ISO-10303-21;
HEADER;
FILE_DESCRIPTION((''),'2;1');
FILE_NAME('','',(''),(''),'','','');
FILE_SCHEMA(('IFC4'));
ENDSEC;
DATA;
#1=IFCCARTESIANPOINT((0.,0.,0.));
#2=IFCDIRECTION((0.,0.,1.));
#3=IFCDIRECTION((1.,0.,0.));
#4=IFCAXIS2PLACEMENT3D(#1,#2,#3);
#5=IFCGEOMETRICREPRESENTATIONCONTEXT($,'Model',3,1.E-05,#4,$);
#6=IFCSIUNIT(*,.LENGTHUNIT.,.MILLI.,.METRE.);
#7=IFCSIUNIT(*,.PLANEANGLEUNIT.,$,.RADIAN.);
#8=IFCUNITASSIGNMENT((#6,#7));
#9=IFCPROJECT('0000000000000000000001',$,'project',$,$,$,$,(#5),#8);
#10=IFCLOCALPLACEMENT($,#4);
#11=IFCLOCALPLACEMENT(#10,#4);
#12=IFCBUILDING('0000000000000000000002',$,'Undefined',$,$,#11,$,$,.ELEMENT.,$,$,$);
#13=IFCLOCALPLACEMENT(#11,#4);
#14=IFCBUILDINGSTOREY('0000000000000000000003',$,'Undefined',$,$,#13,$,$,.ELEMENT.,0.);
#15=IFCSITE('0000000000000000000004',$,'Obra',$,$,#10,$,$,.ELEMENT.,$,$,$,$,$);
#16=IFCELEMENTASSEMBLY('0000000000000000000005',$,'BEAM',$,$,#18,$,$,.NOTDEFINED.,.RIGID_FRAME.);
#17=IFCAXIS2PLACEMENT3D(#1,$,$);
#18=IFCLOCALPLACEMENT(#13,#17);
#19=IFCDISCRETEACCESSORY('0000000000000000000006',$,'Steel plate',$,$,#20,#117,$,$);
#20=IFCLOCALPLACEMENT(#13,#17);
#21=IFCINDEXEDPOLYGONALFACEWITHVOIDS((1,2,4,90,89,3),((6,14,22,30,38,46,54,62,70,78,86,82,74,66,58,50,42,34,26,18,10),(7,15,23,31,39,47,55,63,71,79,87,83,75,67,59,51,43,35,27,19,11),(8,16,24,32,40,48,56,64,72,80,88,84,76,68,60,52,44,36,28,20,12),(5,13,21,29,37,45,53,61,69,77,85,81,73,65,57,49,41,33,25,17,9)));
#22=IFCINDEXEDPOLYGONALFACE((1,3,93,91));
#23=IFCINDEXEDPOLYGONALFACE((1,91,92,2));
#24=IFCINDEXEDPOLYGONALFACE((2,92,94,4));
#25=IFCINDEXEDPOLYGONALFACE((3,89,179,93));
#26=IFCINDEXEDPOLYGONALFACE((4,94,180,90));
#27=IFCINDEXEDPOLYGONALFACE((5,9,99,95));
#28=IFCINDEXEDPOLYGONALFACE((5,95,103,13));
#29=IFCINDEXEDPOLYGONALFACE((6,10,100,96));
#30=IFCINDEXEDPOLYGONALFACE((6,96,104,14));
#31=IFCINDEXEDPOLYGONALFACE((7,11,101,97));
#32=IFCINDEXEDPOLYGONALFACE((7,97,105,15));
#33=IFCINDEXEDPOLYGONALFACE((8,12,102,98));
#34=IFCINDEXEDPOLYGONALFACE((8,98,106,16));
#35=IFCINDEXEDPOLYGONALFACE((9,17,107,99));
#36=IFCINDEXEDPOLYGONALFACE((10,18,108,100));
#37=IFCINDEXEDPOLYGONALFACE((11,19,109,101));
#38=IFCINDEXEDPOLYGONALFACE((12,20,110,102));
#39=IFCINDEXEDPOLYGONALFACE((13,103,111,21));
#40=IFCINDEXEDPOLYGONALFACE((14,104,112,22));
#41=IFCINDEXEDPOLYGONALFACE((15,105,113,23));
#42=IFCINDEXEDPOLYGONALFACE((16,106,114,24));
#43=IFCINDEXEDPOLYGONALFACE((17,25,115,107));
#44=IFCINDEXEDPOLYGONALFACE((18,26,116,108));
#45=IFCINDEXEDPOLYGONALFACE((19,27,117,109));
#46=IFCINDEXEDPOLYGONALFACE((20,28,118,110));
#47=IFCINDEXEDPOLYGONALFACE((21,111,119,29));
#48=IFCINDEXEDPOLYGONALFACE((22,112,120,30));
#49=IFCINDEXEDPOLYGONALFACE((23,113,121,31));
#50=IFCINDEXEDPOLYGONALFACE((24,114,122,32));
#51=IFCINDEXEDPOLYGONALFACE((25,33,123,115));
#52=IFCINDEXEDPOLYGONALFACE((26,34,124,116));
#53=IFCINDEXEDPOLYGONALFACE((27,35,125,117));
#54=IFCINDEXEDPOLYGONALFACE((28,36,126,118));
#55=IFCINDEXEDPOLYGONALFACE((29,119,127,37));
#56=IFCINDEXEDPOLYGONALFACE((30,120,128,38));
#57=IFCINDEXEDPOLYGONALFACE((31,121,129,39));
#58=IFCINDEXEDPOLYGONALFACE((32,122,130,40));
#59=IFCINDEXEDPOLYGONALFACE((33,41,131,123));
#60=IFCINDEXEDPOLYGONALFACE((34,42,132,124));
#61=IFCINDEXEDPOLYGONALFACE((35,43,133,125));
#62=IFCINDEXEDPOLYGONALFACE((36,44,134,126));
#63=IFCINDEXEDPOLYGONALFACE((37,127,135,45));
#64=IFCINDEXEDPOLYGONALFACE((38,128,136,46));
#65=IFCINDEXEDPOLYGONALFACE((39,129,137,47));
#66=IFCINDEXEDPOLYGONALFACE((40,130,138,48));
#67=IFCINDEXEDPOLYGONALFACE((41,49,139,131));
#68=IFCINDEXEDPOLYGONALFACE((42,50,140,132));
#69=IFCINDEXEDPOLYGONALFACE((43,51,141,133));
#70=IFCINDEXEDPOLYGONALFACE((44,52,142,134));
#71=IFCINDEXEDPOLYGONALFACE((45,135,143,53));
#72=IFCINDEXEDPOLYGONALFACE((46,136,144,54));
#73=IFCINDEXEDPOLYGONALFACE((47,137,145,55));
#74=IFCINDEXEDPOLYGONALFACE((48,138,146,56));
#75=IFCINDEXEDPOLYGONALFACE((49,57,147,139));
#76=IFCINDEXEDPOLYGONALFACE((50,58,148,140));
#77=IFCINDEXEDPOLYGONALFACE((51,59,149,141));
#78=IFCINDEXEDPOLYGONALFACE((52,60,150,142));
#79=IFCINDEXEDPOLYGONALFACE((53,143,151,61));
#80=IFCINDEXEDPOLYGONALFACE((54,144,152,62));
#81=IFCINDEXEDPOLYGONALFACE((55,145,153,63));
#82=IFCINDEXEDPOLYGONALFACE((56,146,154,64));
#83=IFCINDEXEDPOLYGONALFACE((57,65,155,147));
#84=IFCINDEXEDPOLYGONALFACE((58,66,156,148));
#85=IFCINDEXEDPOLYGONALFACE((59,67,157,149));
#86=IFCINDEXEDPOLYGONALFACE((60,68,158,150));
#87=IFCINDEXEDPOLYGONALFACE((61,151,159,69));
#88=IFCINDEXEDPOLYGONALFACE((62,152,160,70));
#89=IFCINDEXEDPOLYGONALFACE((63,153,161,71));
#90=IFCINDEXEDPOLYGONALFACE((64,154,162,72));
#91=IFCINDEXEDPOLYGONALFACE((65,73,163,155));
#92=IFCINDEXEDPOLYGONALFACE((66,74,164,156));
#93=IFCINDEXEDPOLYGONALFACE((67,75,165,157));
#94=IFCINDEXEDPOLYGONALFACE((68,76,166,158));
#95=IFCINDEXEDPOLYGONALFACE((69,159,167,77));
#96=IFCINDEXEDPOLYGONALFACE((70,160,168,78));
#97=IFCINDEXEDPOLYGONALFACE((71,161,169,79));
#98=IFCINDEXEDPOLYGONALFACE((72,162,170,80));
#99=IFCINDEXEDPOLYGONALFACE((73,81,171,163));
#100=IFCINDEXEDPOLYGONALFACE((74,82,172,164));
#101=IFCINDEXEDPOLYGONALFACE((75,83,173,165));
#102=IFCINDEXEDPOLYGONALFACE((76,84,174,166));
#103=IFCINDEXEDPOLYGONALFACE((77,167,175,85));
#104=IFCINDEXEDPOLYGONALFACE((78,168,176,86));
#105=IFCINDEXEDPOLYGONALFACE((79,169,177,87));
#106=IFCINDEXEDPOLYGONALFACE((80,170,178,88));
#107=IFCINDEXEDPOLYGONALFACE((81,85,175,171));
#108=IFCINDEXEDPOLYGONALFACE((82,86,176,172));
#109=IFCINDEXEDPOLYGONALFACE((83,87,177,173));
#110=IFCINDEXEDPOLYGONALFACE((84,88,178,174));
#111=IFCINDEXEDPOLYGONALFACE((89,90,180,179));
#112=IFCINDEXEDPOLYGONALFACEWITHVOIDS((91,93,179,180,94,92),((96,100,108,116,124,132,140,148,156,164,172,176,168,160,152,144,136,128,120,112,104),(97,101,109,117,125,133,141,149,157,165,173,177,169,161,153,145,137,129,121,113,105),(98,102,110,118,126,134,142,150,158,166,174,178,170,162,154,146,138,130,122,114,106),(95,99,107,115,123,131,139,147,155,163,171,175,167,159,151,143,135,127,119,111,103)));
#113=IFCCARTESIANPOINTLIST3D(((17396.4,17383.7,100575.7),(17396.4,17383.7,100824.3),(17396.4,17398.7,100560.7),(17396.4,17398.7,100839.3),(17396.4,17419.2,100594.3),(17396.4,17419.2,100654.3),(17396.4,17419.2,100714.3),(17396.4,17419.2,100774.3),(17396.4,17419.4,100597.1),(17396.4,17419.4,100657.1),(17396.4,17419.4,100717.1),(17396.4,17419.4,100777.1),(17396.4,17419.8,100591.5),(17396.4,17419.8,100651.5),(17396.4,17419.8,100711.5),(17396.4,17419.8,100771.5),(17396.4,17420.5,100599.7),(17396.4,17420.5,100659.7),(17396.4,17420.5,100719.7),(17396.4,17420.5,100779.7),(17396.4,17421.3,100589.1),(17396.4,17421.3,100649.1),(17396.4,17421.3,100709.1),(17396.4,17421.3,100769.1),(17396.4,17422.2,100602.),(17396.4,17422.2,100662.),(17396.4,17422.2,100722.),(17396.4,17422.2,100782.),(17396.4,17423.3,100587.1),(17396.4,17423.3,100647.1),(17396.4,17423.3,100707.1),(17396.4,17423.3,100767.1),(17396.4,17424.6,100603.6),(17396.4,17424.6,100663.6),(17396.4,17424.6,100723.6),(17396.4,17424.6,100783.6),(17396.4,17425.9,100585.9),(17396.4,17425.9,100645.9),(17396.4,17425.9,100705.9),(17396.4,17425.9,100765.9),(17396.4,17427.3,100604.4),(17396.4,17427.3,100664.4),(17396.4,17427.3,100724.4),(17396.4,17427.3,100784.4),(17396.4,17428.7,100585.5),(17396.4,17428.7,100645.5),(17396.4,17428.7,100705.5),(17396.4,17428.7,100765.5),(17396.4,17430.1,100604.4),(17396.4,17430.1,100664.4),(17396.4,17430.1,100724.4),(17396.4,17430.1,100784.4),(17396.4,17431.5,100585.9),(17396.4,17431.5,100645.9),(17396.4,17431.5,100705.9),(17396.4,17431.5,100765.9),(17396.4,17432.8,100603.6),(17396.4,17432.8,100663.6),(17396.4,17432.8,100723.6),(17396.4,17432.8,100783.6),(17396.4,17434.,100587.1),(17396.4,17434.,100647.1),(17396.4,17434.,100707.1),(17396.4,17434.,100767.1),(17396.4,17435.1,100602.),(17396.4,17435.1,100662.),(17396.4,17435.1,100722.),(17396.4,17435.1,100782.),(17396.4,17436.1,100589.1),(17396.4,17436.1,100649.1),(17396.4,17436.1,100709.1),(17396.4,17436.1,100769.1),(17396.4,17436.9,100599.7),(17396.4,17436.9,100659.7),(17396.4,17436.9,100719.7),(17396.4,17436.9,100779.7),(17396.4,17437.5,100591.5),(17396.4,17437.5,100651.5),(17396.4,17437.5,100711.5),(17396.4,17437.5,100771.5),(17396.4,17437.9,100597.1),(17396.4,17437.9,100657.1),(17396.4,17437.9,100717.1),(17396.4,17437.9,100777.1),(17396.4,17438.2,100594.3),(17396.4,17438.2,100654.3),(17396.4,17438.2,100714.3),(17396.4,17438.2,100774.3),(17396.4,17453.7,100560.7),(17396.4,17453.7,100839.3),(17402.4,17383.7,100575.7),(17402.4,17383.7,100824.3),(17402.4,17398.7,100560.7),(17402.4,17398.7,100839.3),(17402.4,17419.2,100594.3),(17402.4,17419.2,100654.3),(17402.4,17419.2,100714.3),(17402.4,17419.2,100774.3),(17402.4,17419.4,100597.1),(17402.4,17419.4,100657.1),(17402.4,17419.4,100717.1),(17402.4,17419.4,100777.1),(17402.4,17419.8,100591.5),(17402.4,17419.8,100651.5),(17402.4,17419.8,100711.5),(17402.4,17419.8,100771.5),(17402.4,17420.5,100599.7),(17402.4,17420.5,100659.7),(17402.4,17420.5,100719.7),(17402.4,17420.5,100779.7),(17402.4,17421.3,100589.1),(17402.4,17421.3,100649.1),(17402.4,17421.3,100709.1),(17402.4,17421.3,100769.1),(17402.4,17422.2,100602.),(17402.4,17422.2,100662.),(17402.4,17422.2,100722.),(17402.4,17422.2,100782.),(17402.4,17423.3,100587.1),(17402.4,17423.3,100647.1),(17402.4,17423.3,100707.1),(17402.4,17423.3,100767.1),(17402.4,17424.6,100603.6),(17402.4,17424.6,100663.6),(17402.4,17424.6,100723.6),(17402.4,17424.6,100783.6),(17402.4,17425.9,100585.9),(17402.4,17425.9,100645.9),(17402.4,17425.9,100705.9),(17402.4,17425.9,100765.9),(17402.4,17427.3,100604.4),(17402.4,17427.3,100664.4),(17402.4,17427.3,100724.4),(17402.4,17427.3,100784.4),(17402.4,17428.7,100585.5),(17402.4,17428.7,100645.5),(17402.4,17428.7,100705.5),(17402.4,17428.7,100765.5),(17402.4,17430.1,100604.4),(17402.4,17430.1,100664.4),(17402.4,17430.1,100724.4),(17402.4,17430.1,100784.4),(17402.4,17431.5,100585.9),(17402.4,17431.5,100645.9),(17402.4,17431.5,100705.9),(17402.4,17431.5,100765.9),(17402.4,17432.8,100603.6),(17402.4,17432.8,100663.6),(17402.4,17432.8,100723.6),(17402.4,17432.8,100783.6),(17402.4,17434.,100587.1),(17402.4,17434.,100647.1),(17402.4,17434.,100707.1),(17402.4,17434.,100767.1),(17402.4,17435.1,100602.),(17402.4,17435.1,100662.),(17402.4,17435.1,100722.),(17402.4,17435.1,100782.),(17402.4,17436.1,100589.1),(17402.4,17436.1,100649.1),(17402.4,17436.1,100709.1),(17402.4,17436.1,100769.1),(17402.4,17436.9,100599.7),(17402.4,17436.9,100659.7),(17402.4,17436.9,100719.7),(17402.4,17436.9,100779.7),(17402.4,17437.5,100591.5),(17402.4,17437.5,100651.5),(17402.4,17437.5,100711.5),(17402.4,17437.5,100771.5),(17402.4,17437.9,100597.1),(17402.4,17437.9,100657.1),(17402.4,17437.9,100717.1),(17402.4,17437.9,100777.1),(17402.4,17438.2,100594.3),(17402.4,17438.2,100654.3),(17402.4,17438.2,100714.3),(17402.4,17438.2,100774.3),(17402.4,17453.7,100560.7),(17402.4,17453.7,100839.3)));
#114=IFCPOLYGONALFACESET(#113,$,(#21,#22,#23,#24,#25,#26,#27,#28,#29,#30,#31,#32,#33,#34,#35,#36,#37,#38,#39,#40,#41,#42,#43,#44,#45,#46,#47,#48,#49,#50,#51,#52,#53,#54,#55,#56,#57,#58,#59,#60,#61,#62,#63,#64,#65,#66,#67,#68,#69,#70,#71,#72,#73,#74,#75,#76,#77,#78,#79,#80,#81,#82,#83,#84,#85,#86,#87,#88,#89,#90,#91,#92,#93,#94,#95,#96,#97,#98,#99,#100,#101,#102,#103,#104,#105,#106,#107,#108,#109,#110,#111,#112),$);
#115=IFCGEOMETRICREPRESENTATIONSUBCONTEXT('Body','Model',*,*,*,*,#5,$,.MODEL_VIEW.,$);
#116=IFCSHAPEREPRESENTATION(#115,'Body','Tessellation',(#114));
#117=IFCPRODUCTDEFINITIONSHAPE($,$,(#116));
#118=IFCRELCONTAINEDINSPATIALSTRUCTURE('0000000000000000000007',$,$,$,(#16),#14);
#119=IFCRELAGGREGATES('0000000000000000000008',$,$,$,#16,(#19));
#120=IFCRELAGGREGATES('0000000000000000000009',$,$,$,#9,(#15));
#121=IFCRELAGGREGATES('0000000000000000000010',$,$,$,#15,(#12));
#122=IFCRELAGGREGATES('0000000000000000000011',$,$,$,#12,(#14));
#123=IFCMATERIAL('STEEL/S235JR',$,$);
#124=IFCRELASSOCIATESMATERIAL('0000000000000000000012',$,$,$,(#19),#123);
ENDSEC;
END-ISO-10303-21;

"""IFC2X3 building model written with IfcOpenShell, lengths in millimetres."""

from ifc_helpers import new_model, si_unit, frame, origin_with_axes, origin_2d_with_axis, place, context, subcontext, project, spatial, polyline, circle, outline, extrude, source, transform, mapped, material, element, aggregate, save


model = new_model("IFC2X3")

# Units and contexts
model_context = context("Model", 3, precision=1e-05, world=origin_with_axes())
body_context = subcontext(model_context, "Body", "Model", "MODEL_VIEW")
ifc_project = project(units=[si_unit("LENGTHUNIT", "METRE", prefix="MILLI"), si_unit("PLANEANGLEUNIT", "RADIAN")], contexts=[model_context])

# Site, building, storey
site_placement = place(None, origin_with_axes())
site = spatial("IfcSite", under=ifc_project, at=site_placement, Name="Obra", CompositionType="ELEMENT")
building_placement = place(site_placement, origin_with_axes())
building = spatial("IfcBuilding", under=site, at=building_placement, Name="Undefined", CompositionType="ELEMENT")
storey_placement = place(building_placement, origin_with_axes())
storey = spatial("IfcBuildingStorey", under=building, at=storey_placement, Name="Undefined", CompositionType="ELEMENT", Elevation=0.0)

# Element assembly, discrete accessory, opening
assembly_1_placement = place(storey_placement, origin_with_axes())
assembly_1 = element("IfcElementAssembly", 1, at=assembly_1_placement, inside=storey, Name="BEAM", AssemblyPlace="NOTDEFINED", PredefinedType="RIGID_FRAME")
ifc_material_1 = material(Name="STEEL/S235JR")
discrete_accessory_1_placement = place(assembly_1_placement, frame((17399.4, 17453.7, 100560.7), z_axis=(-1.0, 0.0, 0.0), x_axis=(0.0, -1.0, 0.0)))
discrete_accessory_1 = element("IfcDiscreteAccessory", 2, at=discrete_accessory_1_placement, material=ifc_material_1, Name="Steel plate", context=body_context, shape_type="SweptSolid", body=[
    extrude(outline(polyline([(0.0, 0.0), (55.0, 0.0), (70.0, 15.0), (70.0, 263.6), (55.0, 278.6), (0.0, 278.6), (0.0, 0.0)])), frame((0.0, 0.0, -3.0), z_axis=(0.0, 0.0, 1.0), x_axis=(1.0, 0.0, 0.0)), (0.0, 0.0, 1.0), 6.0),
])
shared_shape_1 = source(origin_with_axes(), body_context, "Body", "SweptSolid", [
    extrude(circle(Radius=9.5, at=origin_2d_with_axis()), frame((0.0, -9.8, 0.0), z_axis=(0.0, 1.0, 0.0), x_axis=(1.0, 0.0, 0.0)), (0.0, 0.0, 1.0), 6.2),
])
opening_1_placement = place(assembly_1_placement, frame((17392.7, 17393.7, 100850.0), z_axis=(0.0, 1.0, 0.0), x_axis=(0.0, 0.0, -1.0)))
element("IfcOpeningElement", 3, at=opening_1_placement, cuts=discrete_accessory_1, ObjectType="Opening", context=body_context, shape_type="MappedRepresentation", body=[
    mapped(shared_shape_1, transform((75.0, 0.0, 35.0))),
    mapped(shared_shape_1, transform((135.0, 0.0, 35.0))),
    mapped(shared_shape_1, transform((195.0, 0.0, 35.0))),
    mapped(shared_shape_1, transform((255.0, 0.0, 35.0))),
])

aggregate(assembly_1, [discrete_accessory_1])

save(model, "model.ifc")
